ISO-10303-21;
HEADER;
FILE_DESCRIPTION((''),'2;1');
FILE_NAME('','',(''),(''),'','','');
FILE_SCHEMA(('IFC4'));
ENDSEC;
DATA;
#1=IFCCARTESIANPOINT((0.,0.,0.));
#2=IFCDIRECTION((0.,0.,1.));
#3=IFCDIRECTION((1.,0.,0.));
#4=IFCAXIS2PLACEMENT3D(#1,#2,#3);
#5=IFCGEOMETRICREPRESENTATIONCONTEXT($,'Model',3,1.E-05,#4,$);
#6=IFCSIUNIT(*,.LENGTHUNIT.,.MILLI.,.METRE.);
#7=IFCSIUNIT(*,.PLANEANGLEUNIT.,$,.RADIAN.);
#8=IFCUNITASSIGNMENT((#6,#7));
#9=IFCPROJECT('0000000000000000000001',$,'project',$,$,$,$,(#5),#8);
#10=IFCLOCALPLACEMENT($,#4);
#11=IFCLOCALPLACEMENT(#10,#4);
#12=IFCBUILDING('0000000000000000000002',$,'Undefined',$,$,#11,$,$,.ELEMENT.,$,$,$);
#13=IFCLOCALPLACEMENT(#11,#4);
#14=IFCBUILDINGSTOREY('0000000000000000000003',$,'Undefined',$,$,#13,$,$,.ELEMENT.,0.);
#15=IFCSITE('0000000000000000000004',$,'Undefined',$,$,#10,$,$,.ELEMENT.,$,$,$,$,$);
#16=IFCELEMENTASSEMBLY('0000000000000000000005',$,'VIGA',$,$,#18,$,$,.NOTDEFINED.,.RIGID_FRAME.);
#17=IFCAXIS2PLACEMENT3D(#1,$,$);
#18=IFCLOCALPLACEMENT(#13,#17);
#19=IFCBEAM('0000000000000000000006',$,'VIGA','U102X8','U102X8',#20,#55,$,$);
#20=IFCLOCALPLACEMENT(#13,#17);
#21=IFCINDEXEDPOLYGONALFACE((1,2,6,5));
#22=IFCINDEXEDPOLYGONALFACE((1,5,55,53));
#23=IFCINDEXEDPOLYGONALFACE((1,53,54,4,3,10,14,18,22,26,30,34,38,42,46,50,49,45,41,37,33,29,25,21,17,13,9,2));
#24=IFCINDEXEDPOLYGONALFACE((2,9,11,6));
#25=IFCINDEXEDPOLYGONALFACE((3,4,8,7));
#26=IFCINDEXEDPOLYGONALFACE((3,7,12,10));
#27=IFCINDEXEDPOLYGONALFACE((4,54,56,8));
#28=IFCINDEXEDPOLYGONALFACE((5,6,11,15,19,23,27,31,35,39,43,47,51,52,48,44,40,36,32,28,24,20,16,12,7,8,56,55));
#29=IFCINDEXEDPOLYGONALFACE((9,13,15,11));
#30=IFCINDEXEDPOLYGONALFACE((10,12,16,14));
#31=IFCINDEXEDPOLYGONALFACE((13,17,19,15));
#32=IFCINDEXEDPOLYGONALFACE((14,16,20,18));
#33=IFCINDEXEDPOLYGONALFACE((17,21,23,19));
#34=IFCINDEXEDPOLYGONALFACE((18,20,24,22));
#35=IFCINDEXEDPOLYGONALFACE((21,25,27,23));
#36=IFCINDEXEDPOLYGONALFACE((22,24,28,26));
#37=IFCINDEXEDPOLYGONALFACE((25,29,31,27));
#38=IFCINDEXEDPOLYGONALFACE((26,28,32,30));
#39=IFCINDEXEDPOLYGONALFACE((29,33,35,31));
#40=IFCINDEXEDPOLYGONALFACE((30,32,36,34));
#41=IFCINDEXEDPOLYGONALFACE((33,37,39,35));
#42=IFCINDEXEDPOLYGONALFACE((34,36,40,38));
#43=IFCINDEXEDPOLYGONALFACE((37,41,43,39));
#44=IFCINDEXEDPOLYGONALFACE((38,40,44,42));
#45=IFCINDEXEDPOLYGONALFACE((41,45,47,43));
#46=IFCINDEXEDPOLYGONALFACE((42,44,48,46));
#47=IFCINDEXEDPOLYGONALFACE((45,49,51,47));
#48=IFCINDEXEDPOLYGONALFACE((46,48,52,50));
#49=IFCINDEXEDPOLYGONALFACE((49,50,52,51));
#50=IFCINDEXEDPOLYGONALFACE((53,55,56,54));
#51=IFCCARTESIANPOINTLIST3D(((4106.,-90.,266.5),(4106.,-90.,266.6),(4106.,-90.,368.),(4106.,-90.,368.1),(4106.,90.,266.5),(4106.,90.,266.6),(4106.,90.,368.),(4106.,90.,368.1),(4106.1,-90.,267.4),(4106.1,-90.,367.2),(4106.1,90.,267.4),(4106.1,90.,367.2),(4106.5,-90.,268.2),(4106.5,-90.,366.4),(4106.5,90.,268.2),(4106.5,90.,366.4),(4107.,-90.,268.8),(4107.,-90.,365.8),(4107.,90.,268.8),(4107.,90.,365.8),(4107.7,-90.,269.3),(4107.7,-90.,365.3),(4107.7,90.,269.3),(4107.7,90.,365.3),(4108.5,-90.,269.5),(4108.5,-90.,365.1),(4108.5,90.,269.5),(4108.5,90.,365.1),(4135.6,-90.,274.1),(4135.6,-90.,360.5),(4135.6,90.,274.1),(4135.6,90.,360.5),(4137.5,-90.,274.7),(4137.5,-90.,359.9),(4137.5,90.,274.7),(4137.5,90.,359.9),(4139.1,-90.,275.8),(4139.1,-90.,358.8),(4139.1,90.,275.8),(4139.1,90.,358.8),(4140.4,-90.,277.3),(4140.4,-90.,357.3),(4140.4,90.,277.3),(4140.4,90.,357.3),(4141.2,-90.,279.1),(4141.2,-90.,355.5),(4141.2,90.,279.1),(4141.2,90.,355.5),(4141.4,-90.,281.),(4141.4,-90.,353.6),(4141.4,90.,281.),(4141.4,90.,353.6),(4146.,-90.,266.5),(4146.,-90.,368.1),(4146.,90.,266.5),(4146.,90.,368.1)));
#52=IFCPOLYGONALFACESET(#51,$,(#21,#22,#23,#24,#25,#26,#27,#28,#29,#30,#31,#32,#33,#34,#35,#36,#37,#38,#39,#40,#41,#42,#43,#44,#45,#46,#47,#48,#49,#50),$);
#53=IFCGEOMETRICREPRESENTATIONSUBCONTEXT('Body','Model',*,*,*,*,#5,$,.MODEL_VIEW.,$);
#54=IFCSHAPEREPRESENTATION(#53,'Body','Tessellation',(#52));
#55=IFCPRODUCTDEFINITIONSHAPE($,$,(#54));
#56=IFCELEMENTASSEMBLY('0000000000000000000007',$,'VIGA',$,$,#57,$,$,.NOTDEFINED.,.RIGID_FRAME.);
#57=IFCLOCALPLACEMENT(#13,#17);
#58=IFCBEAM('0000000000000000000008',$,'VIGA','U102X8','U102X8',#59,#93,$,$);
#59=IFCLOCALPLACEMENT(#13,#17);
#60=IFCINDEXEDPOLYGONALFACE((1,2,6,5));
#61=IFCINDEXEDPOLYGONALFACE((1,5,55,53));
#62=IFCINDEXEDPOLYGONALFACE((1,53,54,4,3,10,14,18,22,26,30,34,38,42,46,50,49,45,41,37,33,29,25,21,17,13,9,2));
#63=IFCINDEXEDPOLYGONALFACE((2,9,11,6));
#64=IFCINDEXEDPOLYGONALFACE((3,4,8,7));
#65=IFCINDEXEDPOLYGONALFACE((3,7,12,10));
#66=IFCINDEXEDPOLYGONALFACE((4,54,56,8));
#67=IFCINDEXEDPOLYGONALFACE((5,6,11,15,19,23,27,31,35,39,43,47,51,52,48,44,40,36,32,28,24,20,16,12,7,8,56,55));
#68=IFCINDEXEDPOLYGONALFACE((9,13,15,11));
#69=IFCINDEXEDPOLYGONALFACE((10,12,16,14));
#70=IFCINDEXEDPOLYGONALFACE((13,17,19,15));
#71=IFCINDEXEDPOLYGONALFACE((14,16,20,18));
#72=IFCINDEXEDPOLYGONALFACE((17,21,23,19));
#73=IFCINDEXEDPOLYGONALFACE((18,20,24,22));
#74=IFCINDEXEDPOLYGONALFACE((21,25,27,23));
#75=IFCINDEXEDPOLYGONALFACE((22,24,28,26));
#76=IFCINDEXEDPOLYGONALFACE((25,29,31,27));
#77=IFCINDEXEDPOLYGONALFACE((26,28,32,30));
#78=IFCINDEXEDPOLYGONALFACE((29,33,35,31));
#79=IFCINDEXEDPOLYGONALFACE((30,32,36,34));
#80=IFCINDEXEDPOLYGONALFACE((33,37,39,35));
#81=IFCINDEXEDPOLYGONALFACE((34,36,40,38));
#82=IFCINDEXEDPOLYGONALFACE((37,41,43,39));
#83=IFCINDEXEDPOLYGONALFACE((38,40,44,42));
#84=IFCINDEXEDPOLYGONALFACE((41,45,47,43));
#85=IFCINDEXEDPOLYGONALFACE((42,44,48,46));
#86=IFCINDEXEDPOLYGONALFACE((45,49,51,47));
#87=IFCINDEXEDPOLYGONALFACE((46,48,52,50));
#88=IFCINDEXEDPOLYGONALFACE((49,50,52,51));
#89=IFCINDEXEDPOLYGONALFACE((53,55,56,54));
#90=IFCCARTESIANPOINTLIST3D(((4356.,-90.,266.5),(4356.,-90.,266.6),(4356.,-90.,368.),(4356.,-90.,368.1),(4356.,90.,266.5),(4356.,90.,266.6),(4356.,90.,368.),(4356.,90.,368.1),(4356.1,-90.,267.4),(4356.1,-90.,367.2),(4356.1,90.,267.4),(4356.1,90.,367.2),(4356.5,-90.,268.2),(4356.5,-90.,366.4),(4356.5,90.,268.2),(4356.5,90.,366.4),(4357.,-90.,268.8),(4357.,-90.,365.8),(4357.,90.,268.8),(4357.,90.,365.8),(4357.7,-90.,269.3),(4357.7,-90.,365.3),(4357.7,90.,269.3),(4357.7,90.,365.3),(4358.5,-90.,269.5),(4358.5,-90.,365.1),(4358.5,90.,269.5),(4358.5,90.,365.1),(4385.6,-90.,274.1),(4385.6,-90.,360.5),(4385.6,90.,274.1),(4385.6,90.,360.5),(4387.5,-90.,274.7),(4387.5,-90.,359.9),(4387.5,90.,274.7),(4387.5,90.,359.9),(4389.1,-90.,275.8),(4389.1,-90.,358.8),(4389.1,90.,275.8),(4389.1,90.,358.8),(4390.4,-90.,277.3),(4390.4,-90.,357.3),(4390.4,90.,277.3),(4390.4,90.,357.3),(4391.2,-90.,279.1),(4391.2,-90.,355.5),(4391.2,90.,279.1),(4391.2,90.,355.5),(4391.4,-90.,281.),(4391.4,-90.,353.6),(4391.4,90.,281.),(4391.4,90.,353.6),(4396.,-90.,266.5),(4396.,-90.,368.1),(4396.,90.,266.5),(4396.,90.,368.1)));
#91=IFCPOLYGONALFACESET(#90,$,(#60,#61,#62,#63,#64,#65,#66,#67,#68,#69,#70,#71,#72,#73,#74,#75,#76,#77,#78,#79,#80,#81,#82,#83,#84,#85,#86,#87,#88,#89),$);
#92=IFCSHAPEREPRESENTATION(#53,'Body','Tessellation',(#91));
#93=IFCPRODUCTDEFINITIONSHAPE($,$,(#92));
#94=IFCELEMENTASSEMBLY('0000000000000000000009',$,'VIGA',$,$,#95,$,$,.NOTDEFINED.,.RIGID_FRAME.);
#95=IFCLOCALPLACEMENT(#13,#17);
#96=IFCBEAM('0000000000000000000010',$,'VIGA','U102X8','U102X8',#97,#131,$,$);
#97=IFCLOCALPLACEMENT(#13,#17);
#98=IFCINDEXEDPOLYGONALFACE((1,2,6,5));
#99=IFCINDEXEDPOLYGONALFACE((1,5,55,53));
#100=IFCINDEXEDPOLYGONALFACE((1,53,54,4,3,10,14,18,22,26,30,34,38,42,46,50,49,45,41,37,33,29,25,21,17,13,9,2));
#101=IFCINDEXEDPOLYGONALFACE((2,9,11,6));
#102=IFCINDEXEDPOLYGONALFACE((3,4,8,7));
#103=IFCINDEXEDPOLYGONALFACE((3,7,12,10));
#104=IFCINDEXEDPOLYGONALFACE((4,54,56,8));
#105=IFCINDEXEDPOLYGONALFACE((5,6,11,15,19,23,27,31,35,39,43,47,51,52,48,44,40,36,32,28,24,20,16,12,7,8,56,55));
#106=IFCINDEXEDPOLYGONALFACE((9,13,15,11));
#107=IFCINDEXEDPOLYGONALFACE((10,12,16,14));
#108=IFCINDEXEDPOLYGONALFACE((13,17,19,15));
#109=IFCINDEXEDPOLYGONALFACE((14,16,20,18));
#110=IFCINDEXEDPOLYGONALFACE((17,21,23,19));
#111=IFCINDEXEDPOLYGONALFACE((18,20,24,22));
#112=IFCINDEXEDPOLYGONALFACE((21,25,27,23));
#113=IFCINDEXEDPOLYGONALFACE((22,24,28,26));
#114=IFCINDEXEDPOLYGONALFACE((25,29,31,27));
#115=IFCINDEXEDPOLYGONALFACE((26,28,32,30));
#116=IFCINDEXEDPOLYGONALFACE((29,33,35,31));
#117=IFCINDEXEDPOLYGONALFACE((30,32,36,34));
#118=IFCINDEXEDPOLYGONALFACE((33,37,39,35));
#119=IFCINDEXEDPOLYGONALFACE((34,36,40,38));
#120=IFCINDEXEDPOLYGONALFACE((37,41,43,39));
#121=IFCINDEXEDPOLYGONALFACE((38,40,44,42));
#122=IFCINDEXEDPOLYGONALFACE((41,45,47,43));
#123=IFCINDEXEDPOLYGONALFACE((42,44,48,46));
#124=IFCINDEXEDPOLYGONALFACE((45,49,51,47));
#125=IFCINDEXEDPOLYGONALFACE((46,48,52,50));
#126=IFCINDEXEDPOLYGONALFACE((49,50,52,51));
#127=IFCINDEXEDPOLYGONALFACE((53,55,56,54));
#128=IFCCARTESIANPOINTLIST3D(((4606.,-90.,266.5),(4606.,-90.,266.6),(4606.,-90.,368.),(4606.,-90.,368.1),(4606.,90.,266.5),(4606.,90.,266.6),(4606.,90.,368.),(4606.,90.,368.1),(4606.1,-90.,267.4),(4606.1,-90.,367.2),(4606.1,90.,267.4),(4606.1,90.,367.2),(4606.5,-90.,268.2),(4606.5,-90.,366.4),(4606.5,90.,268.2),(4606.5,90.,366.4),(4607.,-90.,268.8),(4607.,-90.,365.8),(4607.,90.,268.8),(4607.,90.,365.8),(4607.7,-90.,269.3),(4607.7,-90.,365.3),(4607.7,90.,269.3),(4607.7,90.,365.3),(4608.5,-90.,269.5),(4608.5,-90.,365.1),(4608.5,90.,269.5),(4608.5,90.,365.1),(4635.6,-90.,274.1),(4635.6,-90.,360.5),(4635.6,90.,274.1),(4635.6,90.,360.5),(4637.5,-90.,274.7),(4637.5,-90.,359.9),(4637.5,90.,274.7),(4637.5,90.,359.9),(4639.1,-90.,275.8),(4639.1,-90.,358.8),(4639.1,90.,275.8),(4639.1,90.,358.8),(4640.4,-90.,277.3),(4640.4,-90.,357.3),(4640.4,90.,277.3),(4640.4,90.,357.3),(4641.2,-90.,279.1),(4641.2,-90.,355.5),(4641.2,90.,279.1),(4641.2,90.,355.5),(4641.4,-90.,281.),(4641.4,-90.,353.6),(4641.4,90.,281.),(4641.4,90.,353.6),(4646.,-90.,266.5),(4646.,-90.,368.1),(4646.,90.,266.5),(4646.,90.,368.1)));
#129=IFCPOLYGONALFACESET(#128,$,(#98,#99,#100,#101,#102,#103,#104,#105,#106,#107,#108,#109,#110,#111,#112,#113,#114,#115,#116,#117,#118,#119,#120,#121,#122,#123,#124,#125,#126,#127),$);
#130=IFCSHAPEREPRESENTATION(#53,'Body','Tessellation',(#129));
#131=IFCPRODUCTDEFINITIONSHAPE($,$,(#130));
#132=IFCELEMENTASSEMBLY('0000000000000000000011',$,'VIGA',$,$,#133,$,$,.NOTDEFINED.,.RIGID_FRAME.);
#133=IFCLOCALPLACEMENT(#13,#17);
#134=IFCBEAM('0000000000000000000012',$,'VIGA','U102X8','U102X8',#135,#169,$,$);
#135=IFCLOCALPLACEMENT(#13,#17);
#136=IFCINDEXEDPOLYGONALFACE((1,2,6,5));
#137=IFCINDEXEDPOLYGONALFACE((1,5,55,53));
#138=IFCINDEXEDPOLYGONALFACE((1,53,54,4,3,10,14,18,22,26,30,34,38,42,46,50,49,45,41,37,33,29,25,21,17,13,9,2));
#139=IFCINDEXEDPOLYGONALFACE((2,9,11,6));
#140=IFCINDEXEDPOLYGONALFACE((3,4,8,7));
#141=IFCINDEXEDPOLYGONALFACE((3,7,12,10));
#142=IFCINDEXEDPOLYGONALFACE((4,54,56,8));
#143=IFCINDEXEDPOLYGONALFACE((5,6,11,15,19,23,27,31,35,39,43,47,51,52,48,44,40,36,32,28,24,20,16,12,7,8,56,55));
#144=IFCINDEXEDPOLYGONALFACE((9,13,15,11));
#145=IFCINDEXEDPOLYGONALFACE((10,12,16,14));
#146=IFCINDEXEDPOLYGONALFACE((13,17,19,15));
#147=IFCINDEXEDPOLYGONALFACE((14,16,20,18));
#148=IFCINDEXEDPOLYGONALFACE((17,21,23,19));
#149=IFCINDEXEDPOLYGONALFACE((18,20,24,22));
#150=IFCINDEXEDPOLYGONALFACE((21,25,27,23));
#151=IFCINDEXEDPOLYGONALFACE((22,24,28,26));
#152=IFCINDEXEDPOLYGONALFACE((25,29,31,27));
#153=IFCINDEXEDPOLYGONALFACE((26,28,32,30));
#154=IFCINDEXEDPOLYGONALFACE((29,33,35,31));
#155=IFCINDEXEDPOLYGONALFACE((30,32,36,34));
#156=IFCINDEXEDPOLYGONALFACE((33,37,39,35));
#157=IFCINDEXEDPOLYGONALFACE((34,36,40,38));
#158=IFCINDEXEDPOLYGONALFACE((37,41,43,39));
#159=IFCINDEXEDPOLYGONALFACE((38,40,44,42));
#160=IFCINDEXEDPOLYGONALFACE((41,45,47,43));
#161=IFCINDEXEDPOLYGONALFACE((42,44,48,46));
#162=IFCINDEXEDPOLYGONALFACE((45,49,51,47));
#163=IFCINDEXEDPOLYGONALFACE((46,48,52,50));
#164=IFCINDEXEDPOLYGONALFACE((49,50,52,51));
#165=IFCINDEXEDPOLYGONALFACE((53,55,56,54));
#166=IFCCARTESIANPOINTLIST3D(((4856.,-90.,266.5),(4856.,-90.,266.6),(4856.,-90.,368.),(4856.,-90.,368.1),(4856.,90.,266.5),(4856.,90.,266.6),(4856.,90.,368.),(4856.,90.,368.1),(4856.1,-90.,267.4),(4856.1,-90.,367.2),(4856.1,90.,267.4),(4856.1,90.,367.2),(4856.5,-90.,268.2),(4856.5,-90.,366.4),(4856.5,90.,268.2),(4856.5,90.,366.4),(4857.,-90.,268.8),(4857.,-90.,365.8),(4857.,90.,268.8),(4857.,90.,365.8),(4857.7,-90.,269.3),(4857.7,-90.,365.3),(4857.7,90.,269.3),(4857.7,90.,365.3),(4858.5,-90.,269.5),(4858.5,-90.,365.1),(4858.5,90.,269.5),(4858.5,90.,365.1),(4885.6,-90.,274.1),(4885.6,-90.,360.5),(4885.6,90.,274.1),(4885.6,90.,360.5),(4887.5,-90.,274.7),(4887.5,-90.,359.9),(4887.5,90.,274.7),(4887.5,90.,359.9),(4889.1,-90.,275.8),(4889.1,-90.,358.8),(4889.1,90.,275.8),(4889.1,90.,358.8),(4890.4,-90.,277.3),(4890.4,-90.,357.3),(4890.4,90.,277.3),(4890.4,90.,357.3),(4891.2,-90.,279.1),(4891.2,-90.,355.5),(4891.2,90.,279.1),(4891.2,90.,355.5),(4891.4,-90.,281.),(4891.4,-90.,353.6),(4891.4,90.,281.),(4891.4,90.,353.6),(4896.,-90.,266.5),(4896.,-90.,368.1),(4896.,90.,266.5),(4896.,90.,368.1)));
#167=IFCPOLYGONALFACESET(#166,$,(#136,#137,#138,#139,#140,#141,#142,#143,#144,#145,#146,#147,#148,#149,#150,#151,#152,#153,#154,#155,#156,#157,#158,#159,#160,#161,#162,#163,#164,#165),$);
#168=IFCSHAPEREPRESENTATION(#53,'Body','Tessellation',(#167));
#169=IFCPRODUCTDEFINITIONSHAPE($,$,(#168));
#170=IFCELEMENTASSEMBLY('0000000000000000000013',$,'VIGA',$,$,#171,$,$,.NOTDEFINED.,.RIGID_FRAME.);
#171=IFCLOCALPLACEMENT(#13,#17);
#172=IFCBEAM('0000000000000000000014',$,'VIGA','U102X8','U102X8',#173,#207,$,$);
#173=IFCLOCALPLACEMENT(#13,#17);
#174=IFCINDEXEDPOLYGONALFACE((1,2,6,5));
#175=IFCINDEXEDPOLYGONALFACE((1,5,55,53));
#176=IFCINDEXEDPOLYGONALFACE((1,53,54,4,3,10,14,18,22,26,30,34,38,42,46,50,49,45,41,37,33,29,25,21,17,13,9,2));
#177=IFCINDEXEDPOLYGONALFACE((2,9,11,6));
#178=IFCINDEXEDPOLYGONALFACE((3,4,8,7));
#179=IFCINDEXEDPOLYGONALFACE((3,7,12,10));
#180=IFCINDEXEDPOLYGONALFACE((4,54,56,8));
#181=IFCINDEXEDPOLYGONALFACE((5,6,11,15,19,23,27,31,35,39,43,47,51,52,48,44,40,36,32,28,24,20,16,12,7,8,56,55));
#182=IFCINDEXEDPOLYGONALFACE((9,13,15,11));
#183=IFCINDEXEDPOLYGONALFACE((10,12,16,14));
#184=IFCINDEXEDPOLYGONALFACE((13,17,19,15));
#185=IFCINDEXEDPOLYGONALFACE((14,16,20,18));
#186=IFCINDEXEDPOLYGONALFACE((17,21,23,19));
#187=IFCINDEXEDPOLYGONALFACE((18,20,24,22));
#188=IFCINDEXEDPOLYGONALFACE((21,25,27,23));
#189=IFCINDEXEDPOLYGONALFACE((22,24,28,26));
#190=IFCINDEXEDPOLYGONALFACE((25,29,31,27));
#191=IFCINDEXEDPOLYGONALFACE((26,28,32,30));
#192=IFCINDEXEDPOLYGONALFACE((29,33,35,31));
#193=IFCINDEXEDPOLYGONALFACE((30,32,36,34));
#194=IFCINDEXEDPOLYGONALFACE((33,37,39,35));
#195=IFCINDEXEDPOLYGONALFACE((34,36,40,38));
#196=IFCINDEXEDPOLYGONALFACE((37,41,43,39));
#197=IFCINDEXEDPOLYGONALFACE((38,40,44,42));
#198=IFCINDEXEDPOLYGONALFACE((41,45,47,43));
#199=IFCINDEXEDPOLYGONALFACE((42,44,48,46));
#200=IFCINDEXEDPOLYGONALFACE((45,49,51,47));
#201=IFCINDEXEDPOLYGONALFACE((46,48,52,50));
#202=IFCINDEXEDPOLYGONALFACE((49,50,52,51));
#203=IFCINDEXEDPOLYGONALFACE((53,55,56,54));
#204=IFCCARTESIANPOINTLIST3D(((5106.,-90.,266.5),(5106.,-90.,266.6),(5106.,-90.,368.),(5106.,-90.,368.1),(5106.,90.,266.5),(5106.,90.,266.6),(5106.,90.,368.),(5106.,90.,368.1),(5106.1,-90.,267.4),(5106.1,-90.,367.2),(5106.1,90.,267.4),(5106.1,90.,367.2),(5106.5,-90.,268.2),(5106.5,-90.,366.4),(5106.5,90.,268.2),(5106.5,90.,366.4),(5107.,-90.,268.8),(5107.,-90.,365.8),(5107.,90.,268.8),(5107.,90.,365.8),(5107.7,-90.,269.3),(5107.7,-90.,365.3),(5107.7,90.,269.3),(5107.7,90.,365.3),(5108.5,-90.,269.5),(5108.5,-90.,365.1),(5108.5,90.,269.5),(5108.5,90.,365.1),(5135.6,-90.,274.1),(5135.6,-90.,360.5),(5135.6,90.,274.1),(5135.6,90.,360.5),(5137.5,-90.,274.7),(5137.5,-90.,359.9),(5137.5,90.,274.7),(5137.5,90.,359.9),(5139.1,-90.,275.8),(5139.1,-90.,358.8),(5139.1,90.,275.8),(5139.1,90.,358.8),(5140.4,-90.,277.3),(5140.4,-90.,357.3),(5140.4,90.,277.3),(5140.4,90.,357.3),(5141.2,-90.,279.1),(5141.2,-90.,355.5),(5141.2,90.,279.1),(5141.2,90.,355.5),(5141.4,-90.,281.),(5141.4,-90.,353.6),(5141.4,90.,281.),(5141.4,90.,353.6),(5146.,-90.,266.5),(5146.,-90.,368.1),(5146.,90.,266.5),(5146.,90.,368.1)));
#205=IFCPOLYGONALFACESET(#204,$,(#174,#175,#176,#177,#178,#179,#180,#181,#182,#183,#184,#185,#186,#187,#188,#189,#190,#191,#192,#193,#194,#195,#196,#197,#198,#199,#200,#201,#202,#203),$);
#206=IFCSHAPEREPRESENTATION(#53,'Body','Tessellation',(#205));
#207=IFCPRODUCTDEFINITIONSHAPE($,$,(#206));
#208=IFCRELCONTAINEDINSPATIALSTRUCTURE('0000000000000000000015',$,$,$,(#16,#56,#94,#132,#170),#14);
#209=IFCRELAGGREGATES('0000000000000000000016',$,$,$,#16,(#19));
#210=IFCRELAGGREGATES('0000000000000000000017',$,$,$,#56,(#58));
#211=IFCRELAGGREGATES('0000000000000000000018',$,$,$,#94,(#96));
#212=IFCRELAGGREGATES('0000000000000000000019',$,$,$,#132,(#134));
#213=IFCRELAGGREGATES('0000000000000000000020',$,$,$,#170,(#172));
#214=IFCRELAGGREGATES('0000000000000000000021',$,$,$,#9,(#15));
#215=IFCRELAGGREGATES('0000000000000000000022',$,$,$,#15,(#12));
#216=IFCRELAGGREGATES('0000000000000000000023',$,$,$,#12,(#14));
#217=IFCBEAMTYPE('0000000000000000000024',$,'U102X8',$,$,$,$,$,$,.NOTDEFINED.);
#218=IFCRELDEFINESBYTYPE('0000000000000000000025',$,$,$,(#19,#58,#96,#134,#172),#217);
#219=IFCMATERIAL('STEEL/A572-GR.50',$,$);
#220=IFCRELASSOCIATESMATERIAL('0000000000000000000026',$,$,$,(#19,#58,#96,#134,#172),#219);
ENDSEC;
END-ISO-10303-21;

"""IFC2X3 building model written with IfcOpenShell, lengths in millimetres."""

from ifc_helpers import new_model, si_unit, frame, origin_with_axes, origin_2d_with_axis, place, context, subcontext, project, spatial, u_section, extrude, material, type_object, element, aggregate, save


model = new_model("IFC2X3")

# Units and contexts
model_context = context("Model", 3, precision=1e-05, world=origin_with_axes())
body_context = subcontext(model_context, "Body", "Model", "MODEL_VIEW")
ifc_project = project(units=[si_unit("LENGTHUNIT", "METRE", prefix="MILLI"), si_unit("PLANEANGLEUNIT", "RADIAN")], contexts=[model_context])

# Site, building, storey
site_placement = place(None, origin_with_axes())
site = spatial("IfcSite", under=ifc_project, at=site_placement, Name="Undefined", CompositionType="ELEMENT")
building_placement = place(site_placement, origin_with_axes())
building = spatial("IfcBuilding", under=site, at=building_placement, Name="Undefined", CompositionType="ELEMENT")
storey_placement = place(building_placement, origin_with_axes())
storey = spatial("IfcBuildingStorey", under=building, at=storey_placement, Name="Undefined", CompositionType="ELEMENT", Elevation=0.0)

# Element assemblies, beams
assembly_1_placement = place(storey_placement, origin_with_axes())
assembly_1 = element("IfcElementAssembly", 1, at=assembly_1_placement, inside=storey, Name="VIGA", AssemblyPlace="NOTDEFINED", PredefinedType="RIGID_FRAME")
ifc_material_1 = material(Name="STEEL/A572-GR.50")
beam_type = type_object("IfcBeamType", Name="U102X8", PredefinedType="NOTDEFINED")
beam_1_placement = place(assembly_1_placement, frame((4126.0, 90.0, 317.3), z_axis=(0.0, 0.0, 1.0), x_axis=(0.0, -1.0, 0.0)))
beam_1 = element("IfcBeam", 2, at=beam_1_placement, type_object=beam_type, material=ifc_material_1, Name="VIGA", Description="U102X8", ObjectType="U102X8", context=body_context, shape_type="SweptSolid", body=[
    extrude(u_section(Depth=101.6, FlangeWidth=40.0, WebThickness=4.6, FlangeThickness=6.0, FilletRadius=7.0, EdgeRadius=3.0, FlangeSlope=0.16839, at=origin_2d_with_axis()), frame((180.0, 0.0, 0.0), z_axis=(-1.0, 0.0, 0.0), x_axis=(0.0, -1.0, 0.0)), (0.0, 0.0, 1.0), 180.0),
])
aggregate(assembly_1, [beam_1])
assembly_2_placement = place(storey_placement, origin_with_axes())
assembly_2 = element("IfcElementAssembly", 3, at=assembly_2_placement, inside=storey, Name="VIGA", AssemblyPlace="NOTDEFINED", PredefinedType="RIGID_FRAME")
beam_2_placement = place(assembly_2_placement, frame((4376.0, 90.0, 317.3), z_axis=(0.0, 0.0, 1.0), x_axis=(0.0, -1.0, 0.0)))
beam_2 = element("IfcBeam", 4, at=beam_2_placement, type_object=beam_type, material=ifc_material_1, Name="VIGA", Description="U102X8", ObjectType="U102X8", context=body_context, shape_type="SweptSolid", body=[
    extrude(u_section(Depth=101.6, FlangeWidth=40.0, WebThickness=4.6, FlangeThickness=6.0, FilletRadius=7.0, EdgeRadius=3.0, FlangeSlope=0.16839, at=origin_2d_with_axis()), frame((180.0, 0.0, 0.0), z_axis=(-1.0, 0.0, 0.0), x_axis=(0.0, -1.0, 0.0)), (0.0, 0.0, 1.0), 180.0),
])
aggregate(assembly_2, [beam_2])
assembly_3_placement = place(storey_placement, origin_with_axes())
assembly_3 = element("IfcElementAssembly", 5, at=assembly_3_placement, inside=storey, Name="VIGA", AssemblyPlace="NOTDEFINED", PredefinedType="RIGID_FRAME")
beam_3_placement = place(assembly_3_placement, frame((4626.0, 90.0, 317.3), z_axis=(0.0, 0.0, 1.0), x_axis=(0.0, -1.0, 0.0)))
beam_3 = element("IfcBeam", 6, at=beam_3_placement, type_object=beam_type, material=ifc_material_1, Name="VIGA", Description="U102X8", ObjectType="U102X8", context=body_context, shape_type="SweptSolid", body=[
    extrude(u_section(Depth=101.6, FlangeWidth=40.0, WebThickness=4.6, FlangeThickness=6.0, FilletRadius=7.0, EdgeRadius=3.0, FlangeSlope=0.16839, at=origin_2d_with_axis()), frame((180.0, 0.0, 0.0), z_axis=(-1.0, 0.0, 0.0), x_axis=(0.0, -1.0, 0.0)), (0.0, 0.0, 1.0), 180.0),
])
aggregate(assembly_3, [beam_3])
assembly_4_placement = place(storey_placement, origin_with_axes())
assembly_4 = element("IfcElementAssembly", 7, at=assembly_4_placement, inside=storey, Name="VIGA", AssemblyPlace="NOTDEFINED", PredefinedType="RIGID_FRAME")
beam_4_placement = place(assembly_4_placement, frame((4876.0, 90.0, 317.3), z_axis=(0.0, 0.0, 1.0), x_axis=(0.0, -1.0, 0.0)))
beam_4 = element("IfcBeam", 8, at=beam_4_placement, type_object=beam_type, material=ifc_material_1, Name="VIGA", Description="U102X8", ObjectType="U102X8", context=body_context, shape_type="SweptSolid", body=[
    extrude(u_section(Depth=101.6, FlangeWidth=40.0, WebThickness=4.6, FlangeThickness=6.0, FilletRadius=7.0, EdgeRadius=3.0, FlangeSlope=0.16839, at=origin_2d_with_axis()), frame((180.0, 0.0, 0.0), z_axis=(-1.0, 0.0, 0.0), x_axis=(0.0, -1.0, 0.0)), (0.0, 0.0, 1.0), 180.0),
])
aggregate(assembly_4, [beam_4])
assembly_5_placement = place(storey_placement, origin_with_axes())
assembly_5 = element("IfcElementAssembly", 9, at=assembly_5_placement, inside=storey, Name="VIGA", AssemblyPlace="NOTDEFINED", PredefinedType="RIGID_FRAME")
beam_5_placement = place(assembly_5_placement, frame((5126.0, 90.0, 317.3), z_axis=(0.0, 0.0, 1.0), x_axis=(0.0, -1.0, 0.0)))
beam_5 = element("IfcBeam", 10, at=beam_5_placement, type_object=beam_type, material=ifc_material_1, Name="VIGA", Description="U102X8", ObjectType="U102X8", context=body_context, shape_type="SweptSolid", body=[
    extrude(u_section(Depth=101.6, FlangeWidth=40.0, WebThickness=4.6, FlangeThickness=6.0, FilletRadius=7.0, EdgeRadius=3.0, FlangeSlope=0.16839, at=origin_2d_with_axis()), frame((180.0, 0.0, 0.0), z_axis=(-1.0, 0.0, 0.0), x_axis=(0.0, -1.0, 0.0)), (0.0, 0.0, 1.0), 180.0),
])
aggregate(assembly_5, [beam_5])

save(model, "model.ifc")
